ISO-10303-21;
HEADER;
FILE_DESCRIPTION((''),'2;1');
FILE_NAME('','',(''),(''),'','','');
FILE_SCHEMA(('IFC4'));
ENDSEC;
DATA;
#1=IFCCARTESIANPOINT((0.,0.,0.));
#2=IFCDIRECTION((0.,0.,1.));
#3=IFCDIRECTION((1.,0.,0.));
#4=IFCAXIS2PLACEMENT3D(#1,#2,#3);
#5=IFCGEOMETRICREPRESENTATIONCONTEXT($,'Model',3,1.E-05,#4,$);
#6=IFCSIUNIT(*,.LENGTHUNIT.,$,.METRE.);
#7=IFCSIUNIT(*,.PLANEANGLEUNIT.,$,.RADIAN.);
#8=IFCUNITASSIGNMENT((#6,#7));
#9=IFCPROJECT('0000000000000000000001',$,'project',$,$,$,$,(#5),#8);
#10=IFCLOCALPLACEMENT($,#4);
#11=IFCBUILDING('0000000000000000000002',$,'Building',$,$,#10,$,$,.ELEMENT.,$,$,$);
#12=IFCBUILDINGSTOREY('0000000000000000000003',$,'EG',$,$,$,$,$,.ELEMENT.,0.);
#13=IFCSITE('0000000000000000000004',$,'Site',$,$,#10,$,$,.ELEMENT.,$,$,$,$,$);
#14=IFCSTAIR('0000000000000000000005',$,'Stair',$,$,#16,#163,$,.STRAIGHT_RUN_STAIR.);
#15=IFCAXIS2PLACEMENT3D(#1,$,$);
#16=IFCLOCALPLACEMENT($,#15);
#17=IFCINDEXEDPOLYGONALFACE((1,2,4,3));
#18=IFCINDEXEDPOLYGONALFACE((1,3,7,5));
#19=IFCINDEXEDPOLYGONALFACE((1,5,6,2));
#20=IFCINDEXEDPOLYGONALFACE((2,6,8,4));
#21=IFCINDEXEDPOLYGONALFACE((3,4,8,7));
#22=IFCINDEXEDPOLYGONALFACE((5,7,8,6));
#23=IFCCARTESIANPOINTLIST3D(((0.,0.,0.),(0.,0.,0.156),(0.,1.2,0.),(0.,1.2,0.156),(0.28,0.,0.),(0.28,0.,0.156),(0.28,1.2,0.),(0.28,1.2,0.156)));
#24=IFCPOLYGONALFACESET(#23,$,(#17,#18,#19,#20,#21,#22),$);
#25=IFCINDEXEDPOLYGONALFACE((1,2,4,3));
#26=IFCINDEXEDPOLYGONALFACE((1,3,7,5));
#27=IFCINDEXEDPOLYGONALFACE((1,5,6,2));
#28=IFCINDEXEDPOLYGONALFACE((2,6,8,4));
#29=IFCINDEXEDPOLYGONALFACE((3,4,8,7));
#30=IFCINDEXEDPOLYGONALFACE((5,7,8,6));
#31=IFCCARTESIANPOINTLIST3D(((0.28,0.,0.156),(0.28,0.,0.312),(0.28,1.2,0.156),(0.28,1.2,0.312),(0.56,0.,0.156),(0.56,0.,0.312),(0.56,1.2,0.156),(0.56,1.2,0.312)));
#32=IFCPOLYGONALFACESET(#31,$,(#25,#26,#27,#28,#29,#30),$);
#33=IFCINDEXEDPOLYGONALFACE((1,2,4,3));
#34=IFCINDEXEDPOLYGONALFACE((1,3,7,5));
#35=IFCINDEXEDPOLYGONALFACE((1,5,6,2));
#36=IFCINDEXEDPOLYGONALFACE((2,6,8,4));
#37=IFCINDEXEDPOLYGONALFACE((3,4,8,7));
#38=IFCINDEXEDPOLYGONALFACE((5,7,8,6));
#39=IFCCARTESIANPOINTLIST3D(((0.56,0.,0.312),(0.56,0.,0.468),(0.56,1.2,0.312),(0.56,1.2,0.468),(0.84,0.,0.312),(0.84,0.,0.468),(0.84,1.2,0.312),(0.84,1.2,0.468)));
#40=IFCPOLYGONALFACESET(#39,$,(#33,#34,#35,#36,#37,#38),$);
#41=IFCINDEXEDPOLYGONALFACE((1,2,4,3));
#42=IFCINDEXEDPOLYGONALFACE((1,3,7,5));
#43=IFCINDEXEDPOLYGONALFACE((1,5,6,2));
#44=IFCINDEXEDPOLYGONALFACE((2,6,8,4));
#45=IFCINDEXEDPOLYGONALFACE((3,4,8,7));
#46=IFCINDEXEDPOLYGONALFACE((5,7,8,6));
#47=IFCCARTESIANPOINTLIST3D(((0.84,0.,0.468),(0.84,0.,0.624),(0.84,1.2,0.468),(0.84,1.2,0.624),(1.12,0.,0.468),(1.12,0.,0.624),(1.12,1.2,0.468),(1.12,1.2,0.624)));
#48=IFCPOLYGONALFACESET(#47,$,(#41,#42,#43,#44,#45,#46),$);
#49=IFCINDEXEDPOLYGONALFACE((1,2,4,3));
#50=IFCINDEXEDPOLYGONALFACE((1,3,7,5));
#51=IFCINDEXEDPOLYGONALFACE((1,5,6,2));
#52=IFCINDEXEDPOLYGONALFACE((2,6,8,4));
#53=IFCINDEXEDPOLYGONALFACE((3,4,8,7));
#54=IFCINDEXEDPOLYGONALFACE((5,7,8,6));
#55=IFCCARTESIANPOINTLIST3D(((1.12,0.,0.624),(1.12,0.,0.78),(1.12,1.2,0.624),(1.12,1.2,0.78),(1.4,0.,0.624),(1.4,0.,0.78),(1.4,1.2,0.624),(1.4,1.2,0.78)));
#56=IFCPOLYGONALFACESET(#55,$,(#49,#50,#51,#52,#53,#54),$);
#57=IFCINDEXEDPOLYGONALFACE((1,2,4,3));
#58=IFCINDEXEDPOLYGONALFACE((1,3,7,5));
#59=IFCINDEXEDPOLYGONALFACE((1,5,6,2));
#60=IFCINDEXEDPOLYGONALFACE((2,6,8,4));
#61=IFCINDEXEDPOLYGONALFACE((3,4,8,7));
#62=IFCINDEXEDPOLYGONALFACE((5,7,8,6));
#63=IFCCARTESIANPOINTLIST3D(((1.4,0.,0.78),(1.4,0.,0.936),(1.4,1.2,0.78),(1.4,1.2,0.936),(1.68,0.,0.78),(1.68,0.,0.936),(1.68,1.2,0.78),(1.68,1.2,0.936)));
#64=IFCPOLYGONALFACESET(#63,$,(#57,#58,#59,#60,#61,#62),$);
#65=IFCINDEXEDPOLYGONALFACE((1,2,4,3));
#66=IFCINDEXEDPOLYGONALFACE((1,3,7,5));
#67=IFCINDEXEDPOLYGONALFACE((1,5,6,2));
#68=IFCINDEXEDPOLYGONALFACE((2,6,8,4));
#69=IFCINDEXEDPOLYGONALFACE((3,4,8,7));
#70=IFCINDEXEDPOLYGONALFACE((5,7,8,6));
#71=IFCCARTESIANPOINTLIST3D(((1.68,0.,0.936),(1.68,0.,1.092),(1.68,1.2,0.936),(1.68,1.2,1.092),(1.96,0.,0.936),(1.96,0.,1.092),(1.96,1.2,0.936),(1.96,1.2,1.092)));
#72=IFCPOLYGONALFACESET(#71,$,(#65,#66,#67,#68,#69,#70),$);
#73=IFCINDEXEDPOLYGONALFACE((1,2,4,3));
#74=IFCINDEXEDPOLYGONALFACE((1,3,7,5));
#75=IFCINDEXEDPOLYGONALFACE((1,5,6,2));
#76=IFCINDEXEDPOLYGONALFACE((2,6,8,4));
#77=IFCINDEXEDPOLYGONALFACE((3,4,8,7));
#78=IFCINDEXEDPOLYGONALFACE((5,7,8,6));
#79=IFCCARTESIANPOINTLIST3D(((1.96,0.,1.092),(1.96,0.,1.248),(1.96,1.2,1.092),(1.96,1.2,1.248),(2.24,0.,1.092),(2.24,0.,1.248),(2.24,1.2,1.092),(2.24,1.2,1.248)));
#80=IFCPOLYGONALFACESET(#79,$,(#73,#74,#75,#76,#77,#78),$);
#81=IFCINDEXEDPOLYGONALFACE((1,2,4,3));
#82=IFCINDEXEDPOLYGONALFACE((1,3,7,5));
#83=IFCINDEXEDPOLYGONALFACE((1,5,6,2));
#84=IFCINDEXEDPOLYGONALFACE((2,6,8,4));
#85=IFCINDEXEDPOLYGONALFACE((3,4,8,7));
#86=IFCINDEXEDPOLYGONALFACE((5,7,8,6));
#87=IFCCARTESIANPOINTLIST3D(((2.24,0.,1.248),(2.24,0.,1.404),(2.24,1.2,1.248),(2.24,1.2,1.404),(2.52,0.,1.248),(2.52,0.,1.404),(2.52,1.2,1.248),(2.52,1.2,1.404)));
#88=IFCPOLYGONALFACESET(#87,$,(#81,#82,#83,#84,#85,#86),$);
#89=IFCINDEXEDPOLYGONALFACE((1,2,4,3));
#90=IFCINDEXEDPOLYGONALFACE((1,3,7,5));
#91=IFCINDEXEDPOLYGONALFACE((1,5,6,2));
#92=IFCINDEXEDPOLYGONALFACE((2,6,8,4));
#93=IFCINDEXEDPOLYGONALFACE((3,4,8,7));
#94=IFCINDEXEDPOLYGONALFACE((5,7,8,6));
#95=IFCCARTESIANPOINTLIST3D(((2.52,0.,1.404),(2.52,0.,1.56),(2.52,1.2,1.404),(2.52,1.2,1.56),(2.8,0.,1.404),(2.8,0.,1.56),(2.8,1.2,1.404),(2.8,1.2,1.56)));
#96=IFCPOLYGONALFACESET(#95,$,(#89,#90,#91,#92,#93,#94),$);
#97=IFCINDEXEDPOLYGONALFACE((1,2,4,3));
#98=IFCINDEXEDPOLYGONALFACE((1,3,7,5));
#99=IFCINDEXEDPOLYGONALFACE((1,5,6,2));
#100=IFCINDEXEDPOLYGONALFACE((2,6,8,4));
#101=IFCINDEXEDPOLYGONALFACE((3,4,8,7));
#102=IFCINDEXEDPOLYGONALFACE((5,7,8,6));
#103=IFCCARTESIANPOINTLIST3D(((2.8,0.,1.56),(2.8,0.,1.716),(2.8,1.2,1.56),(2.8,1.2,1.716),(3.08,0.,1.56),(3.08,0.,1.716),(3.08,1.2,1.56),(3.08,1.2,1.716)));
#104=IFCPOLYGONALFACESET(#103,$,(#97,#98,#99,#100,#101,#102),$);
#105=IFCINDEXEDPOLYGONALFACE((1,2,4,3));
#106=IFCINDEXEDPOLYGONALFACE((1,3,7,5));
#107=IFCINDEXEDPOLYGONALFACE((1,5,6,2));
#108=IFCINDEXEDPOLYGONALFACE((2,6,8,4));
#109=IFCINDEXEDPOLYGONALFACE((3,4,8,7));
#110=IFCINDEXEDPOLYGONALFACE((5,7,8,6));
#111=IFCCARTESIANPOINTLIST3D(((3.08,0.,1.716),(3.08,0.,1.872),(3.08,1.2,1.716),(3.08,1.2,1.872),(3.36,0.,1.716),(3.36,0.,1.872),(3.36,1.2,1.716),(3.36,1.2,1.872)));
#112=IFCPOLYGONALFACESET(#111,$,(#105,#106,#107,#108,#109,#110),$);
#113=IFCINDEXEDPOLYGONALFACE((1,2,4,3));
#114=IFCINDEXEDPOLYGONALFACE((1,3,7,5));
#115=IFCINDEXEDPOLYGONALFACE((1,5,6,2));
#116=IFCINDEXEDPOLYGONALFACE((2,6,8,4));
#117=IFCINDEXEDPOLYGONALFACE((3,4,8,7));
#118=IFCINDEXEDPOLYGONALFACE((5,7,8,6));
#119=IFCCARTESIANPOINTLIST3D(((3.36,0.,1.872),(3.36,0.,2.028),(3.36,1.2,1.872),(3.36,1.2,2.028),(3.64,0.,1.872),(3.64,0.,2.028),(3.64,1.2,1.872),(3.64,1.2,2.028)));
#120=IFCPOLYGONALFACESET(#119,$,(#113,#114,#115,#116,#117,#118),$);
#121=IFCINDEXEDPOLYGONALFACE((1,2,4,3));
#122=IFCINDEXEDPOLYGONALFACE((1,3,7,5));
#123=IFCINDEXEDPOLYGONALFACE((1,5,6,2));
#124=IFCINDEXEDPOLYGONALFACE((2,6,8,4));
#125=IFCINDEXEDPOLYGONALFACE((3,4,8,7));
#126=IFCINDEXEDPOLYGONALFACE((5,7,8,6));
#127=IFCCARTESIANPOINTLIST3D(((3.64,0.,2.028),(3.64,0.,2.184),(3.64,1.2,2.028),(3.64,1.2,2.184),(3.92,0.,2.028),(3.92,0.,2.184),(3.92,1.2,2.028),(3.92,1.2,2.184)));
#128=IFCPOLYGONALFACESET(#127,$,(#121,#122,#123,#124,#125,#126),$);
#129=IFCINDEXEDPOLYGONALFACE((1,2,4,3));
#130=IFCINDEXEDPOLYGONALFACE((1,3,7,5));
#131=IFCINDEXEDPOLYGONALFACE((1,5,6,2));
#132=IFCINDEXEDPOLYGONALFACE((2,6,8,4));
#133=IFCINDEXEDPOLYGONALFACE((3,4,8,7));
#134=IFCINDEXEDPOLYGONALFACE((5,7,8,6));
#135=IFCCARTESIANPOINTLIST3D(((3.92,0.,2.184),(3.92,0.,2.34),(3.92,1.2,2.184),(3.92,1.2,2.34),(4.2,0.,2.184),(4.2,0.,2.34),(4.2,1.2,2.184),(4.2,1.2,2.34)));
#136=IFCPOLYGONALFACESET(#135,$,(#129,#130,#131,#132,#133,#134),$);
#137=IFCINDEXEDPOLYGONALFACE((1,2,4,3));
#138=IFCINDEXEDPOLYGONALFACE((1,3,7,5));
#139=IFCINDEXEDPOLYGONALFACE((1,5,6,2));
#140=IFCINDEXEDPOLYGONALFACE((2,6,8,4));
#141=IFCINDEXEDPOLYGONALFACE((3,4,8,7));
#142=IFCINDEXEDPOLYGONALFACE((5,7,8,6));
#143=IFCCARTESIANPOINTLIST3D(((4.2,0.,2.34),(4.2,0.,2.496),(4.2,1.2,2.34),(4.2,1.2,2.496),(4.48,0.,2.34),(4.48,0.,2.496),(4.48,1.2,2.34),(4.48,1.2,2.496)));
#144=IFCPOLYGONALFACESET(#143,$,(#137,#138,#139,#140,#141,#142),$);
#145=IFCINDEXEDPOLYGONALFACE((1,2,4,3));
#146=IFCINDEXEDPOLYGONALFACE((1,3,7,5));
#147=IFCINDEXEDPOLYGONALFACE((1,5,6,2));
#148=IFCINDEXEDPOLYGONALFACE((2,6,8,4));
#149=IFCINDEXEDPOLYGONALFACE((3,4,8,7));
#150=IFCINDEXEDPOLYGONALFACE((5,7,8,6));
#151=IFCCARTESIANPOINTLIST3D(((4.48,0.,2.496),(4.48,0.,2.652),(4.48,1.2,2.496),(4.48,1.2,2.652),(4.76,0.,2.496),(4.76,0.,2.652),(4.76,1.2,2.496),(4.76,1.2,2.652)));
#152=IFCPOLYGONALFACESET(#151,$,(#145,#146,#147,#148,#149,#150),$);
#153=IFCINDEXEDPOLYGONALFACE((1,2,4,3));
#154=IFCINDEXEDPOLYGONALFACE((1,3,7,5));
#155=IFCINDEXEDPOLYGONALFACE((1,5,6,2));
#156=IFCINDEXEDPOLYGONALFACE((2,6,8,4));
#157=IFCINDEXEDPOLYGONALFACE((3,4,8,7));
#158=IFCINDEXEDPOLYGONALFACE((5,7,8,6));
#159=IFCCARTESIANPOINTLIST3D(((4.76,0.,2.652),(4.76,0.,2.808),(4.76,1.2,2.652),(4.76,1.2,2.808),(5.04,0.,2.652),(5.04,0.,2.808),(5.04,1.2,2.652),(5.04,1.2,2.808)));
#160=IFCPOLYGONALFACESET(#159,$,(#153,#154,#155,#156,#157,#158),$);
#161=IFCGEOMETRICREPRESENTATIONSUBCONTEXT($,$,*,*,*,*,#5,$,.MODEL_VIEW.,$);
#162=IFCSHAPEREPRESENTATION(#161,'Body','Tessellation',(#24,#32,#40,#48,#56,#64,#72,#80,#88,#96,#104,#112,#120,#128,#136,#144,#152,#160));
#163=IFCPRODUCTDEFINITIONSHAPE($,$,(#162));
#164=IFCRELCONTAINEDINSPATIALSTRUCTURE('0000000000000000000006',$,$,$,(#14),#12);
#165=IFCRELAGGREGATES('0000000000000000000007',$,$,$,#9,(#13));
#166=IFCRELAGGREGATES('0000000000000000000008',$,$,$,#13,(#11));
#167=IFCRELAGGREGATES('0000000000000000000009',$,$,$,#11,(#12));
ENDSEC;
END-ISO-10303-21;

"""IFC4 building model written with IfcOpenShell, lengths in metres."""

from ifc_helpers import new_model, si_unit, frame, frame_2d, origin, origin_with_axes, place, context, subcontext, project, spatial, rectangle, extrude, element, save


model = new_model("IFC4")

# Units and contexts
model_context = context("Model", 3, precision=1e-05, world=origin_with_axes())
sub_context = subcontext(model_context, None, None, "MODEL_VIEW")
ifc_project = project(units=[si_unit("LENGTHUNIT", "METRE"), si_unit("PLANEANGLEUNIT", "RADIAN")], contexts=[model_context])

# Site, building, storey
placement_1 = place(None, origin_with_axes())
site = spatial("IfcSite", under=ifc_project, at=placement_1, Name="Site", CompositionType="ELEMENT")
building = spatial("IfcBuilding", under=site, at=placement_1, Name="Building", CompositionType="ELEMENT")
storey = spatial("IfcBuildingStorey", under=building, Name="EG", CompositionType="ELEMENT", Elevation=0.0)

# Stair
placement_2 = place(None, origin_with_axes())
placement_3 = place(placement_2, origin())
stair_placement = place(placement_3, origin())
element("IfcStair", 1, at=stair_placement, inside=storey, Name="Stair", PredefinedType="STRAIGHT_RUN_STAIR", context=sub_context, shape_type="SolidModel", body=[
    extrude(rectangle(XDim=0.28, YDim=1.2, at=frame_2d((0.14, 0.6))), origin(), (0.0, 0.0, 1.0), 0.156),
    extrude(rectangle(XDim=0.28, YDim=1.2, at=frame_2d((0.14, 0.6))), frame((0.28, 0.0, 0.156)), (0.0, 0.0, 1.0), 0.156),
    extrude(rectangle(XDim=0.28, YDim=1.2, at=frame_2d((0.14, 0.6))), frame((0.56, 0.0, 0.312)), (0.0, 0.0, 1.0), 0.156),
    extrude(rectangle(XDim=0.28, YDim=1.2, at=frame_2d((0.14, 0.6))), frame((0.84, 0.0, 0.468)), (0.0, 0.0, 1.0), 0.156),
    extrude(rectangle(XDim=0.28, YDim=1.2, at=frame_2d((0.14, 0.6))), frame((1.12, 0.0, 0.624)), (0.0, 0.0, 1.0), 0.156),
    extrude(rectangle(XDim=0.28, YDim=1.2, at=frame_2d((0.14, 0.6))), frame((1.4, 0.0, 0.78)), (0.0, 0.0, 1.0), 0.156),
    extrude(rectangle(XDim=0.28, YDim=1.2, at=frame_2d((0.14, 0.6))), frame((1.68, 0.0, 0.936)), (0.0, 0.0, 1.0), 0.156),
    extrude(rectangle(XDim=0.28, YDim=1.2, at=frame_2d((0.14, 0.6))), frame((1.96, 0.0, 1.092)), (0.0, 0.0, 1.0), 0.156),
    extrude(rectangle(XDim=0.28, YDim=1.2, at=frame_2d((0.14, 0.6))), frame((2.24, 0.0, 1.248)), (0.0, 0.0, 1.0), 0.156),
    extrude(rectangle(XDim=0.28, YDim=1.2, at=frame_2d((0.14, 0.6))), frame((2.52, 0.0, 1.404)), (0.0, 0.0, 1.0), 0.156),
    extrude(rectangle(XDim=0.28, YDim=1.2, at=frame_2d((0.14, 0.6))), frame((2.8, 0.0, 1.56)), (0.0, 0.0, 1.0), 0.156),
    extrude(rectangle(XDim=0.28, YDim=1.2, at=frame_2d((0.14, 0.6))), frame((3.08, 0.0, 1.716)), (0.0, 0.0, 1.0), 0.156),
    extrude(rectangle(XDim=0.28, YDim=1.2, at=frame_2d((0.14, 0.6))), frame((3.36, 0.0, 1.872)), (0.0, 0.0, 1.0), 0.156),
    extrude(rectangle(XDim=0.28, YDim=1.2, at=frame_2d((0.14, 0.6))), frame((3.64, 0.0, 2.028)), (0.0, 0.0, 1.0), 0.156),
    extrude(rectangle(XDim=0.28, YDim=1.2, at=frame_2d((0.14, 0.6))), frame((3.92, 0.0, 2.184)), (0.0, 0.0, 1.0), 0.156),
    extrude(rectangle(XDim=0.28, YDim=1.2, at=frame_2d((0.14, 0.6))), frame((4.2, 0.0, 2.34)), (0.0, 0.0, 1.0), 0.156),
    extrude(rectangle(XDim=0.28, YDim=1.2, at=frame_2d((0.14, 0.6))), frame((4.48, 0.0, 2.496)), (0.0, 0.0, 1.0), 0.156),
    extrude(rectangle(XDim=0.28, YDim=1.2, at=frame_2d((0.14, 0.6))), frame((4.76, 0.0, 2.652)), (0.0, 0.0, 1.0), 0.156),
])

save(model, "model.ifc")
